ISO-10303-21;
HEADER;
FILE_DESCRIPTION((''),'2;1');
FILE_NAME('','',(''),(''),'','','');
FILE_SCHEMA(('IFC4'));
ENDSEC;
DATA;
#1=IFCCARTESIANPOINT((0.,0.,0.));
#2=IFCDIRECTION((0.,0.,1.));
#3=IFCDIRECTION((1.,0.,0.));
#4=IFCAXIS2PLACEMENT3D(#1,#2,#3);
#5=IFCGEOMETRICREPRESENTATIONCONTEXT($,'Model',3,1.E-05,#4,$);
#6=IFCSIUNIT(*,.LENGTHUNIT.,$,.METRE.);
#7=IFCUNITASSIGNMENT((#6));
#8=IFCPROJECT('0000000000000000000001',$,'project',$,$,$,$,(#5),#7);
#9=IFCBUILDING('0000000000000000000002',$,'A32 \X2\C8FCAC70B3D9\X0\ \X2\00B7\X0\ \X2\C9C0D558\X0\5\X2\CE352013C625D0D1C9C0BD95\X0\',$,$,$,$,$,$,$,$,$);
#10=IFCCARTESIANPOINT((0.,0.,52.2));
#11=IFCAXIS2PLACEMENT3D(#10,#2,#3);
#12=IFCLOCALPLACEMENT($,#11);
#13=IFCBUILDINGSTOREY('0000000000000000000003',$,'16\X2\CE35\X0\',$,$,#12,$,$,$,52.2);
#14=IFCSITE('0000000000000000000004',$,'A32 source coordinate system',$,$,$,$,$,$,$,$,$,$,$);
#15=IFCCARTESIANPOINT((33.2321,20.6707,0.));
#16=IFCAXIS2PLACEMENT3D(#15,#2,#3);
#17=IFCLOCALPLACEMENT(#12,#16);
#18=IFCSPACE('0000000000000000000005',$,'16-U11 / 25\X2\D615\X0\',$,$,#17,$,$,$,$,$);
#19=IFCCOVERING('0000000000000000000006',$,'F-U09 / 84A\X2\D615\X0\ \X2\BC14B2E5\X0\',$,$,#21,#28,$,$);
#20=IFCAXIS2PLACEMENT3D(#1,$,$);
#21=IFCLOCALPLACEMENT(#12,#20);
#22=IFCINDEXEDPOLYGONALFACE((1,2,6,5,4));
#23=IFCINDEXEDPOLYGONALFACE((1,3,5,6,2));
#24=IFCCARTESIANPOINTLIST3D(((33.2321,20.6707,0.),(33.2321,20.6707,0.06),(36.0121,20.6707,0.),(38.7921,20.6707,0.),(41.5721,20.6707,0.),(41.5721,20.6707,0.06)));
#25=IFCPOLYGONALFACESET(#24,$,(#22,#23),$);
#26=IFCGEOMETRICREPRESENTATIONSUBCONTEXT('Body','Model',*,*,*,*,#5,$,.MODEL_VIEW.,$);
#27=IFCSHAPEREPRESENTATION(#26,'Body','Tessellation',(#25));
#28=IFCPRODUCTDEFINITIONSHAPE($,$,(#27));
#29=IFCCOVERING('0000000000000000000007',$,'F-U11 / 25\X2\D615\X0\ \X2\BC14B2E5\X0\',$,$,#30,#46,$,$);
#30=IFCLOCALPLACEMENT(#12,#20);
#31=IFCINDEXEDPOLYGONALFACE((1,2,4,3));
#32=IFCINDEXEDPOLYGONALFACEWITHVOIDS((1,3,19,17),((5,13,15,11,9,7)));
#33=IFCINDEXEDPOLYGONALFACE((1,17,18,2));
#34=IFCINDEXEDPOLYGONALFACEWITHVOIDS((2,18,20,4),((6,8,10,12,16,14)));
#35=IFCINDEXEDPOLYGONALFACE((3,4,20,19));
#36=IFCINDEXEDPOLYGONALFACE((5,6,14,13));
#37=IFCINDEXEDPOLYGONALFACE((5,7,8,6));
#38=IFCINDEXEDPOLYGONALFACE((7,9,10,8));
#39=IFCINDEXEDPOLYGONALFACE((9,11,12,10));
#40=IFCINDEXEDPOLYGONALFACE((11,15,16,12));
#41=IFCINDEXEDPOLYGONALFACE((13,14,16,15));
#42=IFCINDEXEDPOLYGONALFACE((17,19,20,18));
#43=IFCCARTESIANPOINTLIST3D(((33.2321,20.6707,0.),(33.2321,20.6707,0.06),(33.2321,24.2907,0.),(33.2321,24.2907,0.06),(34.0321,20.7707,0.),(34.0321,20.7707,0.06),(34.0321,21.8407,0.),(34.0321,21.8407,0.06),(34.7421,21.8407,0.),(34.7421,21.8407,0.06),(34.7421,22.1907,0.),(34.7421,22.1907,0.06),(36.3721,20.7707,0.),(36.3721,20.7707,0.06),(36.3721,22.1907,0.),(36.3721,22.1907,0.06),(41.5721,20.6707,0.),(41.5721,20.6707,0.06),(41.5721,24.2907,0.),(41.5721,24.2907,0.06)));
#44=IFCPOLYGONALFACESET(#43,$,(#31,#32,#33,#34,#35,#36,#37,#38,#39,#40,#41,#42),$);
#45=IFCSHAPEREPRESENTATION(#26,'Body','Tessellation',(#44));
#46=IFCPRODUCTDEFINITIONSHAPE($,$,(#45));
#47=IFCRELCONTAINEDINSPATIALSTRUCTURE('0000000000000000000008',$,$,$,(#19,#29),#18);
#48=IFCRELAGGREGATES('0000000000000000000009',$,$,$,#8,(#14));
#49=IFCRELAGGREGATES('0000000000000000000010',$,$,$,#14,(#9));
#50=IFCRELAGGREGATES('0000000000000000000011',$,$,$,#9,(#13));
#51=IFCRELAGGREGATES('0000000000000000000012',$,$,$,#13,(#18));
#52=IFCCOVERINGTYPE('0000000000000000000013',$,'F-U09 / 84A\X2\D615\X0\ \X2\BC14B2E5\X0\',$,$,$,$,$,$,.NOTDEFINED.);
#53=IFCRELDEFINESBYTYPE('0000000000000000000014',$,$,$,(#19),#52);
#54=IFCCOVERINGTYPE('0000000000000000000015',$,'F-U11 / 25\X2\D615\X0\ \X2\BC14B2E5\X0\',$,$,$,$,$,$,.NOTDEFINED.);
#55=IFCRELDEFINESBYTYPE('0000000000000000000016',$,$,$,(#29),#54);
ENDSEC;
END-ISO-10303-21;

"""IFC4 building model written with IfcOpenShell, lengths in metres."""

from ifc_helpers import new_model, si_unit, frame, origin, origin_with_axes, place, context, subcontext, project, spatial, polyline, outline, extrude, source, transform, mapped, type_object, type_shapes, element, save


model = new_model("IFC4")

# Units and contexts
model_context = context("Model", 3, precision=1e-05, world=origin_with_axes())
body_context = subcontext(model_context, "Body", "Model", "MODEL_VIEW")
ifc_project = project(units=[si_unit("LENGTHUNIT", "METRE")], contexts=[model_context])

# Site, building, storey
site = spatial("IfcSite", under=ifc_project, Name="A32 source coordinate system")
building = spatial("IfcBuilding", under=site, Name="A32 주거동 · 지하5층–옥탑지붕")
storey_placement = place(None, frame((0.0, 0.0, 52.2), z_axis=(0.0, 0.0, 1.0), x_axis=(1.0, 0.0, 0.0)))
storey = spatial("IfcBuildingStorey", under=building, at=storey_placement, Name="16층", Elevation=52.2)

# Shared definitions
space_1_placement = place(storey_placement, frame((33.2321, 20.6707, 0.0), z_axis=(0.0, 0.0, 1.0), x_axis=(1.0, 0.0, 0.0)))
space_1 = spatial("IfcSpace", under=storey, at=space_1_placement, Name="16-U11 / 25형")

# Coverings
covering_type_1 = type_object("IfcCoveringType", Name="F-U09 / 84A형 바닥", PredefinedType="NOTDEFINED")
shared_shape_1 = source(origin(), body_context, "Body", "SweptSolid", [
    extrude(outline(polyline([(0.0, 0.0), (8.34, 0.0), (8.34, 0.0), (0.0, 0.0), (0.0, 0.0)])), origin(), (0.0, 0.0, 1.0), 0.06),
])
type_shapes(covering_type_1, [shared_shape_1])
covering_1_placement = place(space_1_placement, origin_with_axes())
element("IfcCovering", 1, at=covering_1_placement, inside=space_1, type_object=covering_type_1, Name="F-U09 / 84A형 바닥", context=body_context, shape_type="MappedRepresentation", body=[
    mapped(shared_shape_1, transform((0.0, 0.0, 0.0), scale=1.0)),
])
covering_type_2 = type_object("IfcCoveringType", Name="F-U11 / 25형 바닥", PredefinedType="NOTDEFINED")
shared_shape_2 = source(origin(), body_context, "Body", "SweptSolid", [
    extrude(outline(polyline([(0.0, 0.0), (0.0, 3.62), (8.34, 3.62), (8.34, 0.0), (0.0, 0.0)]), holes=[polyline([(1.51, 1.17), (0.8, 1.17), (0.8, 0.1), (3.14, 0.1), (3.14, 1.52), (1.51, 1.52), (1.51, 1.17)])]), origin(), (0.0, 0.0, 1.0), 0.06),
])
type_shapes(covering_type_2, [shared_shape_2])
covering_2_placement = place(space_1_placement, origin_with_axes())
element("IfcCovering", 2, at=covering_2_placement, inside=space_1, type_object=covering_type_2, Name="F-U11 / 25형 바닥", context=body_context, shape_type="MappedRepresentation", body=[
    mapped(shared_shape_2, transform((0.0, 0.0, 0.0), scale=1.0)),
])

save(model, "model.ifc")
